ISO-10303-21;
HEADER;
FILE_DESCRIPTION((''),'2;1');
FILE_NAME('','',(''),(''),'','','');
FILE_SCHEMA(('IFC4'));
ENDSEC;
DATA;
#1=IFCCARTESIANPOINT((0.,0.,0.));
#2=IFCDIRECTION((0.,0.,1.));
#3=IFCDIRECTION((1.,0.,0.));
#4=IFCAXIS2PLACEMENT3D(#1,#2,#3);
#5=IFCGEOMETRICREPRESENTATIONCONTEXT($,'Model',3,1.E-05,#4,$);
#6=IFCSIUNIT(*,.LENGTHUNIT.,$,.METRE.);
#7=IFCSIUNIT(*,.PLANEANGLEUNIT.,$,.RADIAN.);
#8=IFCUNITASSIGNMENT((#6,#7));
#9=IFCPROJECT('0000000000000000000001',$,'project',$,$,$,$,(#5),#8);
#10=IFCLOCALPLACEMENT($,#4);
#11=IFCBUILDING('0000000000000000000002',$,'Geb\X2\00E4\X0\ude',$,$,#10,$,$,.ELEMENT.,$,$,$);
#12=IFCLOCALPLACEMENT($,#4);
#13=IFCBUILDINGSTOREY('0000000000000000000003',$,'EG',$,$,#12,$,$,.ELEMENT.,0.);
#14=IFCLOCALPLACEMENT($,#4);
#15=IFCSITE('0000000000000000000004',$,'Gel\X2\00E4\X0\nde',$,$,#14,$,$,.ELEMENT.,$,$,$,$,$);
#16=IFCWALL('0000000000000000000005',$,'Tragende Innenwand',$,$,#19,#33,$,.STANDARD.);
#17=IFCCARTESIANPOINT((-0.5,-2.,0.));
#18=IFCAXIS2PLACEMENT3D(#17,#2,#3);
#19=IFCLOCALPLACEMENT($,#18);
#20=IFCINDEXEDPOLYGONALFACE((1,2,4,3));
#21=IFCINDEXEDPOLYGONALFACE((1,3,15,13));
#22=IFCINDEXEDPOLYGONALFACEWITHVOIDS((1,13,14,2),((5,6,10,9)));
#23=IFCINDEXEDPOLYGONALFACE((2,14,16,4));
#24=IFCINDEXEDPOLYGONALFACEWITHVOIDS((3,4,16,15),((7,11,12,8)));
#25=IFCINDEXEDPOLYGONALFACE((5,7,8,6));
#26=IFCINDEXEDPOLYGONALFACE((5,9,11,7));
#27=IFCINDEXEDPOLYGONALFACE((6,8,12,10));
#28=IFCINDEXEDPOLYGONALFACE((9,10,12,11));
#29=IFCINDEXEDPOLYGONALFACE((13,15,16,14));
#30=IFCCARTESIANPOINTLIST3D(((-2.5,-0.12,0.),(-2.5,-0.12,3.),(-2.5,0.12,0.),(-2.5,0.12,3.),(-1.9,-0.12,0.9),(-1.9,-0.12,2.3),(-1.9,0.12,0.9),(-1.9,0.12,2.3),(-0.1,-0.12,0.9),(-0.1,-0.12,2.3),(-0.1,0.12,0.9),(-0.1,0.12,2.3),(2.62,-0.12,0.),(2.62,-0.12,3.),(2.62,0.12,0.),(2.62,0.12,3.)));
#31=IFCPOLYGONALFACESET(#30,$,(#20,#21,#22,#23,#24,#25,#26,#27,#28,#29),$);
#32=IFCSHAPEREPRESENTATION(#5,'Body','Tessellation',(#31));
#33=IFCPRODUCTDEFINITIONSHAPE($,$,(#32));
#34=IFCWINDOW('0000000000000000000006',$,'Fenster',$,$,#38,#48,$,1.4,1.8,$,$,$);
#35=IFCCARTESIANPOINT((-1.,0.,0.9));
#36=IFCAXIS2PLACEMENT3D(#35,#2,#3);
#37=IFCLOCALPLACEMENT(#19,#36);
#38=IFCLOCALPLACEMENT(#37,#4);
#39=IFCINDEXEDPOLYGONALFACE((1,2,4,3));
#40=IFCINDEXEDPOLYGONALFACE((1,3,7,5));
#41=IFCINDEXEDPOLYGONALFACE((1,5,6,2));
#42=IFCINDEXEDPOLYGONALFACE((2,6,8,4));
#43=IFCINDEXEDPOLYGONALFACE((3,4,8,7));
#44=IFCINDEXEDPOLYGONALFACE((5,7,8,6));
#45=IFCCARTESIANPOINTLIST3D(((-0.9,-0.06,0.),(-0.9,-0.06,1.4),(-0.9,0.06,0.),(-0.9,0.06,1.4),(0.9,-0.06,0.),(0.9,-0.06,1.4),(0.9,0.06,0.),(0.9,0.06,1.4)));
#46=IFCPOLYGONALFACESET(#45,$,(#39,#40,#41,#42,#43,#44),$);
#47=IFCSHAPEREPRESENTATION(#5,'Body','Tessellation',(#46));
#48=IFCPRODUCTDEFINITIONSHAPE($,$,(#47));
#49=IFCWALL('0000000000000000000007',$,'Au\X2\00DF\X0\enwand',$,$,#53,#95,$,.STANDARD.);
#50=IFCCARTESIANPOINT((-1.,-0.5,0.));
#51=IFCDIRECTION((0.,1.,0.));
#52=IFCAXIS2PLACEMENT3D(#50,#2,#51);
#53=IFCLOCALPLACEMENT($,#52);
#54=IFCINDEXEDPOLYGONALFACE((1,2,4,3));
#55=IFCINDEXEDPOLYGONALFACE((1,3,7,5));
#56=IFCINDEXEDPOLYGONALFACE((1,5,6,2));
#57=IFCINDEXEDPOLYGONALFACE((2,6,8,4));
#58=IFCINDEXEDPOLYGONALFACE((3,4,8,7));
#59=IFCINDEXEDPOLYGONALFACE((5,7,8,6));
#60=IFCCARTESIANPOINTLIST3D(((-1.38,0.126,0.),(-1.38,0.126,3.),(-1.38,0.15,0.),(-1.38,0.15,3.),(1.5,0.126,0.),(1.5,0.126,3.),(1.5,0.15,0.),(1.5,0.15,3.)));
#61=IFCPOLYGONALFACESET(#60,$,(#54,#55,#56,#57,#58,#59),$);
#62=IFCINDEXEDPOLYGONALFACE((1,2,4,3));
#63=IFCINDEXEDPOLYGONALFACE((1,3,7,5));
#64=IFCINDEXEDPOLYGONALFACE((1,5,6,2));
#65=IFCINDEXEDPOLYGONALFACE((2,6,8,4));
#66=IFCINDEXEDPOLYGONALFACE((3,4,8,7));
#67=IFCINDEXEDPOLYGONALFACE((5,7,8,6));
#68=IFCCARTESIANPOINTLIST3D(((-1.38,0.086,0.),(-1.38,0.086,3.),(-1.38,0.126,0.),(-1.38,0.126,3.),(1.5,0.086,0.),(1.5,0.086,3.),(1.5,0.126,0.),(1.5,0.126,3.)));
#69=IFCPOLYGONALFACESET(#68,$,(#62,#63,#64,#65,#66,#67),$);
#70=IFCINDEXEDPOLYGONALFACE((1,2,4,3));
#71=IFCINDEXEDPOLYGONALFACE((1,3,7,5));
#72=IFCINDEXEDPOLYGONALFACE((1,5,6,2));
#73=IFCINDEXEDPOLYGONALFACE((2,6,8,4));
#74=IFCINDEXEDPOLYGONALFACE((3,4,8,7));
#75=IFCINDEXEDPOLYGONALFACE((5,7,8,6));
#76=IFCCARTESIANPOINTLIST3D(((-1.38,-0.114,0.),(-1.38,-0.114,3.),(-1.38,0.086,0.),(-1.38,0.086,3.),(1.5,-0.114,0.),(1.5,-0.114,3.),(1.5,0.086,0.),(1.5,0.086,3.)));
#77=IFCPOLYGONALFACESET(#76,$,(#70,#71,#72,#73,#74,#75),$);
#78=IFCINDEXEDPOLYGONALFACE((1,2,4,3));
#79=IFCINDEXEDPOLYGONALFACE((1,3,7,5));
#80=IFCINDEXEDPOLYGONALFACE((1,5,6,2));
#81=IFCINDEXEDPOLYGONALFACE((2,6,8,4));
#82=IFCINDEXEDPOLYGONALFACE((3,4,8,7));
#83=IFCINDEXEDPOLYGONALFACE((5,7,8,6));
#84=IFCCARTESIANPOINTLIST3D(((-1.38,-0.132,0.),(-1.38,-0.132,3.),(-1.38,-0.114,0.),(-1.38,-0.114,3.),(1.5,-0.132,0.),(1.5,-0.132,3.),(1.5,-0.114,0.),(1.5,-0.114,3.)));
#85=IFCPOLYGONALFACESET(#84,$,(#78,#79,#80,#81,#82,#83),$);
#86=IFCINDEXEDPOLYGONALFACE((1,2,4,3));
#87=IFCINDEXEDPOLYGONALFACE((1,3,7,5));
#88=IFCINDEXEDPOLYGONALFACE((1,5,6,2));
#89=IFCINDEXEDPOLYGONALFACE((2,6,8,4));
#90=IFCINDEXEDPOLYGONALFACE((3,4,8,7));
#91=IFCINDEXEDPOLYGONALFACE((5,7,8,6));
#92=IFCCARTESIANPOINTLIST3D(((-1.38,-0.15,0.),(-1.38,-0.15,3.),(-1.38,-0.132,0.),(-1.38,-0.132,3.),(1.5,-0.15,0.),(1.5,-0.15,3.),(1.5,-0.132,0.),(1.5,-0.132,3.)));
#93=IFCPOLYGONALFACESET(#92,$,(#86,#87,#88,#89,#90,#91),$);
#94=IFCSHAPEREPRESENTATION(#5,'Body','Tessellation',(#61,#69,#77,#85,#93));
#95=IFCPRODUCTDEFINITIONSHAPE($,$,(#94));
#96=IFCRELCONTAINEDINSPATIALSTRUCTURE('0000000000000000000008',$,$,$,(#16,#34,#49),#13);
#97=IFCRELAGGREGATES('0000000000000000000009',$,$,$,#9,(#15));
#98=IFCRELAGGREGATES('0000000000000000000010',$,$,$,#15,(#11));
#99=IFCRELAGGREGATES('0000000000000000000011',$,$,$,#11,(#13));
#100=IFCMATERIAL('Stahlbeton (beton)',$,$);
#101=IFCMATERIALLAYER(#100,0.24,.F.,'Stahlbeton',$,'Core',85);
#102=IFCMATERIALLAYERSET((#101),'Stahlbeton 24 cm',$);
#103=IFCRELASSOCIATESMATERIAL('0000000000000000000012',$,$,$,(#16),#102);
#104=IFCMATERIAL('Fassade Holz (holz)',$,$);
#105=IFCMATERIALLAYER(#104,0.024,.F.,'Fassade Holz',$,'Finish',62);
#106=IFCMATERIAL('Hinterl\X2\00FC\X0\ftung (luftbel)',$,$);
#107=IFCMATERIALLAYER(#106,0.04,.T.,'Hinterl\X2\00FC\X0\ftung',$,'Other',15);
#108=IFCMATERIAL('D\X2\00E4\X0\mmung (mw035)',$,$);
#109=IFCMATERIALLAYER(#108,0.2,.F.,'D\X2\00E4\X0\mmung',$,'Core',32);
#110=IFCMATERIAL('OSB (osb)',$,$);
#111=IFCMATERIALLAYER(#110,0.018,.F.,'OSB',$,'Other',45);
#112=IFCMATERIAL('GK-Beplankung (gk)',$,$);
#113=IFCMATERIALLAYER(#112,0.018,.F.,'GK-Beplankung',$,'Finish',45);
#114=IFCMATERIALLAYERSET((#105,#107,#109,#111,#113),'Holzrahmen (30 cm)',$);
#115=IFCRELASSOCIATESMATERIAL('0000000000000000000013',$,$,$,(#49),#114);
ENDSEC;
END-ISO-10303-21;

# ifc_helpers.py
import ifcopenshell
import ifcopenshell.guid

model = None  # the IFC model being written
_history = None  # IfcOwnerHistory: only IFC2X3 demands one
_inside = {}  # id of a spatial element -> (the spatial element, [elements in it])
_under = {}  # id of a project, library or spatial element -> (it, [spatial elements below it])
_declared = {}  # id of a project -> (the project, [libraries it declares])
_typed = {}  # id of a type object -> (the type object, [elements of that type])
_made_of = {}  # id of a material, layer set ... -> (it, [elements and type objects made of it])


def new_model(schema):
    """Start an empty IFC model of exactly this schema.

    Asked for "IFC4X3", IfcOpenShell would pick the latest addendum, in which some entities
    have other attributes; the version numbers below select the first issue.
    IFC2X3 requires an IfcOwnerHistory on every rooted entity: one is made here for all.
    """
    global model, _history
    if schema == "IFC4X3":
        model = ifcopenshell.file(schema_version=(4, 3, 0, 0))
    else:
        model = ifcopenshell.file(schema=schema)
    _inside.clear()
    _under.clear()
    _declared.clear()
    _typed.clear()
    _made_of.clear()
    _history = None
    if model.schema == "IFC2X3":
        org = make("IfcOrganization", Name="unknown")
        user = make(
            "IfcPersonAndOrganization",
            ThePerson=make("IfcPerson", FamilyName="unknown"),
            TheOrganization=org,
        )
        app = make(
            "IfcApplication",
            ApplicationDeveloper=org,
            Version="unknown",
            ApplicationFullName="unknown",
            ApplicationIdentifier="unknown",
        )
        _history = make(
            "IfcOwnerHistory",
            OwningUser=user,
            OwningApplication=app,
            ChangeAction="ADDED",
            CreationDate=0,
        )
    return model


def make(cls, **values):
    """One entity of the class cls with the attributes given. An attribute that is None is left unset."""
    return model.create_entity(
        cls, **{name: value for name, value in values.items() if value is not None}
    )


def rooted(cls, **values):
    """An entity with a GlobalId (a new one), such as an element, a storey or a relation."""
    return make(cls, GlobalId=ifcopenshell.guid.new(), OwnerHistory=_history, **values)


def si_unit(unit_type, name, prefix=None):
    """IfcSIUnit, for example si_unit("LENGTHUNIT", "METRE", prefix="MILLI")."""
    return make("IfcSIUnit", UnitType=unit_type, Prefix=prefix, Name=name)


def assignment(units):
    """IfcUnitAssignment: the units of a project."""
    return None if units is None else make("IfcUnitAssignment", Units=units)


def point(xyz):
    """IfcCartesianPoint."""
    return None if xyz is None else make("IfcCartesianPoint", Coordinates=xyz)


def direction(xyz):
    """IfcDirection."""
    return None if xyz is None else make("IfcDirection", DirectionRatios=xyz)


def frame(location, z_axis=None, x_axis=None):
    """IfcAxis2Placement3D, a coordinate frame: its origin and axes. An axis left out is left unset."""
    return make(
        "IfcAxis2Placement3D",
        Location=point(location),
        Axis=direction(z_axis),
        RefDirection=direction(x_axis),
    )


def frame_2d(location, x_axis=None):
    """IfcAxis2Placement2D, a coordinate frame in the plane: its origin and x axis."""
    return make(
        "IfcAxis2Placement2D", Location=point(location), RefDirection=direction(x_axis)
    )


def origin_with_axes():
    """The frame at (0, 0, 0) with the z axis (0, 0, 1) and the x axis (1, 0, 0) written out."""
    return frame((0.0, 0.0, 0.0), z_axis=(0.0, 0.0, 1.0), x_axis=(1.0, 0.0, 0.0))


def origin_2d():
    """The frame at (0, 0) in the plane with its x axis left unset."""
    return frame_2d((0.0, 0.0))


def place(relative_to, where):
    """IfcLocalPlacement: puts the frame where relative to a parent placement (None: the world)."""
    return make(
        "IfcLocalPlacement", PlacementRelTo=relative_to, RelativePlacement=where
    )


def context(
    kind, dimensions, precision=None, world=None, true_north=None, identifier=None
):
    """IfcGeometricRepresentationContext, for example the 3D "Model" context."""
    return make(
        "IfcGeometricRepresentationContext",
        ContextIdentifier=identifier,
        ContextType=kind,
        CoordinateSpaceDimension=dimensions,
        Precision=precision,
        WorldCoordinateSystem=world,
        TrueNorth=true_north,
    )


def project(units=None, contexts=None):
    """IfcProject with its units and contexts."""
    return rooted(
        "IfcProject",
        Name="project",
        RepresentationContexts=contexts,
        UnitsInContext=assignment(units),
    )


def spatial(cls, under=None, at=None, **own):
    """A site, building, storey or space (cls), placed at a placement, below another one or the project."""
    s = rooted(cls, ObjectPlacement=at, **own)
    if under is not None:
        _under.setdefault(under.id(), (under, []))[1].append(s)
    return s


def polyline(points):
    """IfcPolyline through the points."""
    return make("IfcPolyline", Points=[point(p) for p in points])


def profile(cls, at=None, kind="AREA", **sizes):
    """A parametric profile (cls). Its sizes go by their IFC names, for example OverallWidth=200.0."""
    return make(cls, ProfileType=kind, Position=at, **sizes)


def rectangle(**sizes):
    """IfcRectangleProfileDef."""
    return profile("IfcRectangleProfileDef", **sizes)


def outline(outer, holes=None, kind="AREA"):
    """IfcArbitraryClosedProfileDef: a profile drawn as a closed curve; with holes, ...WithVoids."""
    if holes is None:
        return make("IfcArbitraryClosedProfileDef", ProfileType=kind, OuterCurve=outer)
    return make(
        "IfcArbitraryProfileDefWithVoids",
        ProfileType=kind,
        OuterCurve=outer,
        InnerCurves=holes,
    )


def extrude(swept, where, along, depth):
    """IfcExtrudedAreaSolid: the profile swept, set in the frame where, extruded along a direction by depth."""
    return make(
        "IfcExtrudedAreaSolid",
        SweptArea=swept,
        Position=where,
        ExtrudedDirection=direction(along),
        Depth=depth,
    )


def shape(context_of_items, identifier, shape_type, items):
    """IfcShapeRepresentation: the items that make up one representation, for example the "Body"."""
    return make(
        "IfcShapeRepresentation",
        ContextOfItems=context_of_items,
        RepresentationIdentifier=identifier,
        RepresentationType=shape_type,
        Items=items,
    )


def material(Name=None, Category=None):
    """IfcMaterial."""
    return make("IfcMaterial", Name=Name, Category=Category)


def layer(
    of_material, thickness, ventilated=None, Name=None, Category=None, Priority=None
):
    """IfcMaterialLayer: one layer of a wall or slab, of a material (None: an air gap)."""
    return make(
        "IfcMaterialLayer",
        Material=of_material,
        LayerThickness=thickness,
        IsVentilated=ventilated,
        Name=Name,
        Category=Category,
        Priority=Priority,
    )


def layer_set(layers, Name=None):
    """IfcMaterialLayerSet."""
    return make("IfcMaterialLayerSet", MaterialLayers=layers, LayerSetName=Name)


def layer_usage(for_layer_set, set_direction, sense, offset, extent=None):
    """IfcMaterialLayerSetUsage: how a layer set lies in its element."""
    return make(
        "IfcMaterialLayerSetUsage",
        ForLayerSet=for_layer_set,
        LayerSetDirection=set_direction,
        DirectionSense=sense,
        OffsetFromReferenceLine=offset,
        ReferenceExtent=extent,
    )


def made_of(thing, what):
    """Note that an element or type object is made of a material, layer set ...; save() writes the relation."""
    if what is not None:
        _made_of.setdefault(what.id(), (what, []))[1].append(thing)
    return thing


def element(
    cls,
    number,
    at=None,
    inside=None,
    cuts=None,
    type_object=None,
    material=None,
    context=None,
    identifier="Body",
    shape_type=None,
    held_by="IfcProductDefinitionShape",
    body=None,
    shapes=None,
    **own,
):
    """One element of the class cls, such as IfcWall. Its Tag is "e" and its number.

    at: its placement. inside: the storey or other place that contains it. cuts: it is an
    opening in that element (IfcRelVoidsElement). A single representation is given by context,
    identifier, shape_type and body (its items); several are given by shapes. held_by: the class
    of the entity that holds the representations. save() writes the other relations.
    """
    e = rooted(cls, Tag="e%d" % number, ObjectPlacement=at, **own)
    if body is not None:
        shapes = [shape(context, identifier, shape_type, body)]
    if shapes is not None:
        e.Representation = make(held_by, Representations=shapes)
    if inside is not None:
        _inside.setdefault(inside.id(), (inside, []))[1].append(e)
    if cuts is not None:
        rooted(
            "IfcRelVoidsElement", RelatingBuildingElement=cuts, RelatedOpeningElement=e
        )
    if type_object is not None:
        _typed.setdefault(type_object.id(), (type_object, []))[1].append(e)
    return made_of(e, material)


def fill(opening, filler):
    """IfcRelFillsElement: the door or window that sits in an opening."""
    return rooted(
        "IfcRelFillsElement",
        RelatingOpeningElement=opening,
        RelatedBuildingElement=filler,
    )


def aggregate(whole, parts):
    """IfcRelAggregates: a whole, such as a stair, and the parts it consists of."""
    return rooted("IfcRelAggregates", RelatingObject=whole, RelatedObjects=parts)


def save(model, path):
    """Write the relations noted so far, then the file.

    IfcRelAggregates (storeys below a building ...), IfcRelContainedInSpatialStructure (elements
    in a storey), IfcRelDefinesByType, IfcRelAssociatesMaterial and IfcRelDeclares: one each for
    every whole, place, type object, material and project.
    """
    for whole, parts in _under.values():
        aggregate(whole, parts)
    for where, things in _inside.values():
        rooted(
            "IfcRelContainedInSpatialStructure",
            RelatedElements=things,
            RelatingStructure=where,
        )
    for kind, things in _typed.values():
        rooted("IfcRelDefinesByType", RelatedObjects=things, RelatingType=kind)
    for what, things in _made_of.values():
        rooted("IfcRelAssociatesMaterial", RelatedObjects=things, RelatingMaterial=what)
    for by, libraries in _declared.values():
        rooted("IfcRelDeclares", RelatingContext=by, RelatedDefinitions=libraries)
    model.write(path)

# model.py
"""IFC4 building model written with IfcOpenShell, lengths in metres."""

from ifc_helpers import new_model, si_unit, frame, origin_with_axes, origin_2d, place, context, project, spatial, polyline, rectangle, outline, extrude, material, layer, layer_set, layer_usage, element, fill, save


model = new_model("IFC4")

# Units and contexts
model_context = context("Model", 3, precision=1e-05, world=origin_with_axes())
ifc_project = project(units=[si_unit("LENGTHUNIT", "METRE"), si_unit("PLANEANGLEUNIT", "RADIAN")], contexts=[model_context])

# Site, building, storey
site_placement = place(None, origin_with_axes())
site = spatial("IfcSite", under=ifc_project, at=site_placement, Name="Gelände", CompositionType="ELEMENT")
building_placement = place(None, origin_with_axes())
building = spatial("IfcBuilding", under=site, at=building_placement, Name="Gebäude", CompositionType="ELEMENT")
storey_placement = place(None, origin_with_axes())
storey = spatial("IfcBuildingStorey", under=building, at=storey_placement, Name="EG", CompositionType="ELEMENT", Elevation=0.0)

# Shared definitions
ifc_material_1 = material(Name="Dämmung (mw035)")

# Wall, opening, window
ifc_material_2 = material(Name="Stahlbeton (beton)")
ifc_layer_1 = layer(ifc_material_2, 0.24, ventilated=False, Name="Stahlbeton", Category="Core", Priority=85)
ifc_layer_set_1 = layer_set([ifc_layer_1], Name="Stahlbeton 24 cm")
ifc_layer_usage_1 = layer_usage(ifc_layer_set_1, "AXIS2", "NEGATIVE", 0.12)
wall_1_placement = place(None, frame((-0.5, -2.0, 0.0), z_axis=(0.0, 0.0, 1.0), x_axis=(1.0, 0.0, 0.0)))
wall_1 = element("IfcWall", 1, at=wall_1_placement, inside=storey, material=ifc_layer_usage_1, Name="Tragende Innenwand", PredefinedType="STANDARD", context=model_context, shape_type="SweptSolid", body=[
    extrude(outline(polyline([(-2.5, -0.12), (2.62, -0.12), (2.62, 0.12), (-2.5, 0.12), (-2.5, -0.12)])), origin_with_axes(), (0.0, 0.0, 1.0), 3.0),
])
opening_placement = place(wall_1_placement, frame((-1.0, 0.0, 0.9), z_axis=(0.0, 0.0, 1.0), x_axis=(1.0, 0.0, 0.0)))
opening = element("IfcOpeningElement", 2, at=opening_placement, cuts=wall_1, PredefinedType="OPENING", context=model_context, shape_type="SweptSolid", body=[
    extrude(rectangle(XDim=1.8, YDim=0.28, at=origin_2d()), origin_with_axes(), (0.0, 0.0, 1.0), 1.4),
])
window_placement = place(opening_placement, origin_with_axes())
window = element("IfcWindow", 3, at=window_placement, inside=storey, Name="Fenster", OverallHeight=1.4, OverallWidth=1.8, context=model_context, shape_type="SweptSolid", body=[
    extrude(rectangle(XDim=1.8, YDim=0.12, at=origin_2d()), origin_with_axes(), (0.0, 0.0, 1.0), 1.4),
])
fill(opening, window)

# Wall
ifc_material_3 = material(Name="Fassade Holz (holz)")
ifc_layer_2 = layer(ifc_material_3, 0.024, ventilated=False, Name="Fassade Holz", Category="Finish", Priority=62)
ifc_material_4 = material(Name="Hinterlüftung (luftbel)")
ifc_layer_3 = layer(ifc_material_4, 0.04, ventilated=True, Name="Hinterlüftung", Category="Other", Priority=15)
ifc_layer_4 = layer(ifc_material_1, 0.2, ventilated=False, Name="Dämmung", Category="Core", Priority=32)
ifc_material_5 = material(Name="OSB (osb)")
ifc_layer_5 = layer(ifc_material_5, 0.018, ventilated=False, Name="OSB", Category="Other", Priority=45)
ifc_material_6 = material(Name="GK-Beplankung (gk)")
ifc_layer_6 = layer(ifc_material_6, 0.018, ventilated=False, Name="GK-Beplankung", Category="Finish", Priority=45)
ifc_layer_set_2 = layer_set([ifc_layer_2, ifc_layer_3, ifc_layer_4, ifc_layer_5, ifc_layer_6], Name="Holzrahmen (30 cm)")
ifc_layer_usage_2 = layer_usage(ifc_layer_set_2, "AXIS2", "NEGATIVE", 0.15)
wall_2_placement = place(None, frame((-1.0, -0.5, 0.0), z_axis=(0.0, 0.0, 1.0), x_axis=(0.0, 1.0, 0.0)))
element("IfcWall", 4, at=wall_2_placement, inside=storey, material=ifc_layer_usage_2, Name="Außenwand", PredefinedType="STANDARD", context=model_context, shape_type="SweptSolid", body=[
    extrude(outline(polyline([(-1.38, 0.126), (1.5, 0.126), (1.5, 0.15), (-1.38, 0.15), (-1.38, 0.126)])), origin_with_axes(), (0.0, 0.0, 1.0), 3.0),
    extrude(outline(polyline([(-1.38, 0.086), (1.5, 0.086), (1.5, 0.126), (-1.38, 0.126), (-1.38, 0.086)])), origin_with_axes(), (0.0, 0.0, 1.0), 3.0),
    extrude(outline(polyline([(-1.38, -0.114), (1.5, -0.114), (1.5, 0.086), (-1.38, 0.086), (-1.38, -0.114)])), origin_with_axes(), (0.0, 0.0, 1.0), 3.0),
    extrude(outline(polyline([(-1.38, -0.132), (1.5, -0.132), (1.5, -0.114), (-1.38, -0.114), (-1.38, -0.132)])), origin_with_axes(), (0.0, 0.0, 1.0), 3.0),
    extrude(outline(polyline([(-1.38, -0.15), (1.5, -0.15), (1.5, -0.132), (-1.38, -0.132), (-1.38, -0.15)])), origin_with_axes(), (0.0, 0.0, 1.0), 3.0),
])

save(model, "model.ifc")
